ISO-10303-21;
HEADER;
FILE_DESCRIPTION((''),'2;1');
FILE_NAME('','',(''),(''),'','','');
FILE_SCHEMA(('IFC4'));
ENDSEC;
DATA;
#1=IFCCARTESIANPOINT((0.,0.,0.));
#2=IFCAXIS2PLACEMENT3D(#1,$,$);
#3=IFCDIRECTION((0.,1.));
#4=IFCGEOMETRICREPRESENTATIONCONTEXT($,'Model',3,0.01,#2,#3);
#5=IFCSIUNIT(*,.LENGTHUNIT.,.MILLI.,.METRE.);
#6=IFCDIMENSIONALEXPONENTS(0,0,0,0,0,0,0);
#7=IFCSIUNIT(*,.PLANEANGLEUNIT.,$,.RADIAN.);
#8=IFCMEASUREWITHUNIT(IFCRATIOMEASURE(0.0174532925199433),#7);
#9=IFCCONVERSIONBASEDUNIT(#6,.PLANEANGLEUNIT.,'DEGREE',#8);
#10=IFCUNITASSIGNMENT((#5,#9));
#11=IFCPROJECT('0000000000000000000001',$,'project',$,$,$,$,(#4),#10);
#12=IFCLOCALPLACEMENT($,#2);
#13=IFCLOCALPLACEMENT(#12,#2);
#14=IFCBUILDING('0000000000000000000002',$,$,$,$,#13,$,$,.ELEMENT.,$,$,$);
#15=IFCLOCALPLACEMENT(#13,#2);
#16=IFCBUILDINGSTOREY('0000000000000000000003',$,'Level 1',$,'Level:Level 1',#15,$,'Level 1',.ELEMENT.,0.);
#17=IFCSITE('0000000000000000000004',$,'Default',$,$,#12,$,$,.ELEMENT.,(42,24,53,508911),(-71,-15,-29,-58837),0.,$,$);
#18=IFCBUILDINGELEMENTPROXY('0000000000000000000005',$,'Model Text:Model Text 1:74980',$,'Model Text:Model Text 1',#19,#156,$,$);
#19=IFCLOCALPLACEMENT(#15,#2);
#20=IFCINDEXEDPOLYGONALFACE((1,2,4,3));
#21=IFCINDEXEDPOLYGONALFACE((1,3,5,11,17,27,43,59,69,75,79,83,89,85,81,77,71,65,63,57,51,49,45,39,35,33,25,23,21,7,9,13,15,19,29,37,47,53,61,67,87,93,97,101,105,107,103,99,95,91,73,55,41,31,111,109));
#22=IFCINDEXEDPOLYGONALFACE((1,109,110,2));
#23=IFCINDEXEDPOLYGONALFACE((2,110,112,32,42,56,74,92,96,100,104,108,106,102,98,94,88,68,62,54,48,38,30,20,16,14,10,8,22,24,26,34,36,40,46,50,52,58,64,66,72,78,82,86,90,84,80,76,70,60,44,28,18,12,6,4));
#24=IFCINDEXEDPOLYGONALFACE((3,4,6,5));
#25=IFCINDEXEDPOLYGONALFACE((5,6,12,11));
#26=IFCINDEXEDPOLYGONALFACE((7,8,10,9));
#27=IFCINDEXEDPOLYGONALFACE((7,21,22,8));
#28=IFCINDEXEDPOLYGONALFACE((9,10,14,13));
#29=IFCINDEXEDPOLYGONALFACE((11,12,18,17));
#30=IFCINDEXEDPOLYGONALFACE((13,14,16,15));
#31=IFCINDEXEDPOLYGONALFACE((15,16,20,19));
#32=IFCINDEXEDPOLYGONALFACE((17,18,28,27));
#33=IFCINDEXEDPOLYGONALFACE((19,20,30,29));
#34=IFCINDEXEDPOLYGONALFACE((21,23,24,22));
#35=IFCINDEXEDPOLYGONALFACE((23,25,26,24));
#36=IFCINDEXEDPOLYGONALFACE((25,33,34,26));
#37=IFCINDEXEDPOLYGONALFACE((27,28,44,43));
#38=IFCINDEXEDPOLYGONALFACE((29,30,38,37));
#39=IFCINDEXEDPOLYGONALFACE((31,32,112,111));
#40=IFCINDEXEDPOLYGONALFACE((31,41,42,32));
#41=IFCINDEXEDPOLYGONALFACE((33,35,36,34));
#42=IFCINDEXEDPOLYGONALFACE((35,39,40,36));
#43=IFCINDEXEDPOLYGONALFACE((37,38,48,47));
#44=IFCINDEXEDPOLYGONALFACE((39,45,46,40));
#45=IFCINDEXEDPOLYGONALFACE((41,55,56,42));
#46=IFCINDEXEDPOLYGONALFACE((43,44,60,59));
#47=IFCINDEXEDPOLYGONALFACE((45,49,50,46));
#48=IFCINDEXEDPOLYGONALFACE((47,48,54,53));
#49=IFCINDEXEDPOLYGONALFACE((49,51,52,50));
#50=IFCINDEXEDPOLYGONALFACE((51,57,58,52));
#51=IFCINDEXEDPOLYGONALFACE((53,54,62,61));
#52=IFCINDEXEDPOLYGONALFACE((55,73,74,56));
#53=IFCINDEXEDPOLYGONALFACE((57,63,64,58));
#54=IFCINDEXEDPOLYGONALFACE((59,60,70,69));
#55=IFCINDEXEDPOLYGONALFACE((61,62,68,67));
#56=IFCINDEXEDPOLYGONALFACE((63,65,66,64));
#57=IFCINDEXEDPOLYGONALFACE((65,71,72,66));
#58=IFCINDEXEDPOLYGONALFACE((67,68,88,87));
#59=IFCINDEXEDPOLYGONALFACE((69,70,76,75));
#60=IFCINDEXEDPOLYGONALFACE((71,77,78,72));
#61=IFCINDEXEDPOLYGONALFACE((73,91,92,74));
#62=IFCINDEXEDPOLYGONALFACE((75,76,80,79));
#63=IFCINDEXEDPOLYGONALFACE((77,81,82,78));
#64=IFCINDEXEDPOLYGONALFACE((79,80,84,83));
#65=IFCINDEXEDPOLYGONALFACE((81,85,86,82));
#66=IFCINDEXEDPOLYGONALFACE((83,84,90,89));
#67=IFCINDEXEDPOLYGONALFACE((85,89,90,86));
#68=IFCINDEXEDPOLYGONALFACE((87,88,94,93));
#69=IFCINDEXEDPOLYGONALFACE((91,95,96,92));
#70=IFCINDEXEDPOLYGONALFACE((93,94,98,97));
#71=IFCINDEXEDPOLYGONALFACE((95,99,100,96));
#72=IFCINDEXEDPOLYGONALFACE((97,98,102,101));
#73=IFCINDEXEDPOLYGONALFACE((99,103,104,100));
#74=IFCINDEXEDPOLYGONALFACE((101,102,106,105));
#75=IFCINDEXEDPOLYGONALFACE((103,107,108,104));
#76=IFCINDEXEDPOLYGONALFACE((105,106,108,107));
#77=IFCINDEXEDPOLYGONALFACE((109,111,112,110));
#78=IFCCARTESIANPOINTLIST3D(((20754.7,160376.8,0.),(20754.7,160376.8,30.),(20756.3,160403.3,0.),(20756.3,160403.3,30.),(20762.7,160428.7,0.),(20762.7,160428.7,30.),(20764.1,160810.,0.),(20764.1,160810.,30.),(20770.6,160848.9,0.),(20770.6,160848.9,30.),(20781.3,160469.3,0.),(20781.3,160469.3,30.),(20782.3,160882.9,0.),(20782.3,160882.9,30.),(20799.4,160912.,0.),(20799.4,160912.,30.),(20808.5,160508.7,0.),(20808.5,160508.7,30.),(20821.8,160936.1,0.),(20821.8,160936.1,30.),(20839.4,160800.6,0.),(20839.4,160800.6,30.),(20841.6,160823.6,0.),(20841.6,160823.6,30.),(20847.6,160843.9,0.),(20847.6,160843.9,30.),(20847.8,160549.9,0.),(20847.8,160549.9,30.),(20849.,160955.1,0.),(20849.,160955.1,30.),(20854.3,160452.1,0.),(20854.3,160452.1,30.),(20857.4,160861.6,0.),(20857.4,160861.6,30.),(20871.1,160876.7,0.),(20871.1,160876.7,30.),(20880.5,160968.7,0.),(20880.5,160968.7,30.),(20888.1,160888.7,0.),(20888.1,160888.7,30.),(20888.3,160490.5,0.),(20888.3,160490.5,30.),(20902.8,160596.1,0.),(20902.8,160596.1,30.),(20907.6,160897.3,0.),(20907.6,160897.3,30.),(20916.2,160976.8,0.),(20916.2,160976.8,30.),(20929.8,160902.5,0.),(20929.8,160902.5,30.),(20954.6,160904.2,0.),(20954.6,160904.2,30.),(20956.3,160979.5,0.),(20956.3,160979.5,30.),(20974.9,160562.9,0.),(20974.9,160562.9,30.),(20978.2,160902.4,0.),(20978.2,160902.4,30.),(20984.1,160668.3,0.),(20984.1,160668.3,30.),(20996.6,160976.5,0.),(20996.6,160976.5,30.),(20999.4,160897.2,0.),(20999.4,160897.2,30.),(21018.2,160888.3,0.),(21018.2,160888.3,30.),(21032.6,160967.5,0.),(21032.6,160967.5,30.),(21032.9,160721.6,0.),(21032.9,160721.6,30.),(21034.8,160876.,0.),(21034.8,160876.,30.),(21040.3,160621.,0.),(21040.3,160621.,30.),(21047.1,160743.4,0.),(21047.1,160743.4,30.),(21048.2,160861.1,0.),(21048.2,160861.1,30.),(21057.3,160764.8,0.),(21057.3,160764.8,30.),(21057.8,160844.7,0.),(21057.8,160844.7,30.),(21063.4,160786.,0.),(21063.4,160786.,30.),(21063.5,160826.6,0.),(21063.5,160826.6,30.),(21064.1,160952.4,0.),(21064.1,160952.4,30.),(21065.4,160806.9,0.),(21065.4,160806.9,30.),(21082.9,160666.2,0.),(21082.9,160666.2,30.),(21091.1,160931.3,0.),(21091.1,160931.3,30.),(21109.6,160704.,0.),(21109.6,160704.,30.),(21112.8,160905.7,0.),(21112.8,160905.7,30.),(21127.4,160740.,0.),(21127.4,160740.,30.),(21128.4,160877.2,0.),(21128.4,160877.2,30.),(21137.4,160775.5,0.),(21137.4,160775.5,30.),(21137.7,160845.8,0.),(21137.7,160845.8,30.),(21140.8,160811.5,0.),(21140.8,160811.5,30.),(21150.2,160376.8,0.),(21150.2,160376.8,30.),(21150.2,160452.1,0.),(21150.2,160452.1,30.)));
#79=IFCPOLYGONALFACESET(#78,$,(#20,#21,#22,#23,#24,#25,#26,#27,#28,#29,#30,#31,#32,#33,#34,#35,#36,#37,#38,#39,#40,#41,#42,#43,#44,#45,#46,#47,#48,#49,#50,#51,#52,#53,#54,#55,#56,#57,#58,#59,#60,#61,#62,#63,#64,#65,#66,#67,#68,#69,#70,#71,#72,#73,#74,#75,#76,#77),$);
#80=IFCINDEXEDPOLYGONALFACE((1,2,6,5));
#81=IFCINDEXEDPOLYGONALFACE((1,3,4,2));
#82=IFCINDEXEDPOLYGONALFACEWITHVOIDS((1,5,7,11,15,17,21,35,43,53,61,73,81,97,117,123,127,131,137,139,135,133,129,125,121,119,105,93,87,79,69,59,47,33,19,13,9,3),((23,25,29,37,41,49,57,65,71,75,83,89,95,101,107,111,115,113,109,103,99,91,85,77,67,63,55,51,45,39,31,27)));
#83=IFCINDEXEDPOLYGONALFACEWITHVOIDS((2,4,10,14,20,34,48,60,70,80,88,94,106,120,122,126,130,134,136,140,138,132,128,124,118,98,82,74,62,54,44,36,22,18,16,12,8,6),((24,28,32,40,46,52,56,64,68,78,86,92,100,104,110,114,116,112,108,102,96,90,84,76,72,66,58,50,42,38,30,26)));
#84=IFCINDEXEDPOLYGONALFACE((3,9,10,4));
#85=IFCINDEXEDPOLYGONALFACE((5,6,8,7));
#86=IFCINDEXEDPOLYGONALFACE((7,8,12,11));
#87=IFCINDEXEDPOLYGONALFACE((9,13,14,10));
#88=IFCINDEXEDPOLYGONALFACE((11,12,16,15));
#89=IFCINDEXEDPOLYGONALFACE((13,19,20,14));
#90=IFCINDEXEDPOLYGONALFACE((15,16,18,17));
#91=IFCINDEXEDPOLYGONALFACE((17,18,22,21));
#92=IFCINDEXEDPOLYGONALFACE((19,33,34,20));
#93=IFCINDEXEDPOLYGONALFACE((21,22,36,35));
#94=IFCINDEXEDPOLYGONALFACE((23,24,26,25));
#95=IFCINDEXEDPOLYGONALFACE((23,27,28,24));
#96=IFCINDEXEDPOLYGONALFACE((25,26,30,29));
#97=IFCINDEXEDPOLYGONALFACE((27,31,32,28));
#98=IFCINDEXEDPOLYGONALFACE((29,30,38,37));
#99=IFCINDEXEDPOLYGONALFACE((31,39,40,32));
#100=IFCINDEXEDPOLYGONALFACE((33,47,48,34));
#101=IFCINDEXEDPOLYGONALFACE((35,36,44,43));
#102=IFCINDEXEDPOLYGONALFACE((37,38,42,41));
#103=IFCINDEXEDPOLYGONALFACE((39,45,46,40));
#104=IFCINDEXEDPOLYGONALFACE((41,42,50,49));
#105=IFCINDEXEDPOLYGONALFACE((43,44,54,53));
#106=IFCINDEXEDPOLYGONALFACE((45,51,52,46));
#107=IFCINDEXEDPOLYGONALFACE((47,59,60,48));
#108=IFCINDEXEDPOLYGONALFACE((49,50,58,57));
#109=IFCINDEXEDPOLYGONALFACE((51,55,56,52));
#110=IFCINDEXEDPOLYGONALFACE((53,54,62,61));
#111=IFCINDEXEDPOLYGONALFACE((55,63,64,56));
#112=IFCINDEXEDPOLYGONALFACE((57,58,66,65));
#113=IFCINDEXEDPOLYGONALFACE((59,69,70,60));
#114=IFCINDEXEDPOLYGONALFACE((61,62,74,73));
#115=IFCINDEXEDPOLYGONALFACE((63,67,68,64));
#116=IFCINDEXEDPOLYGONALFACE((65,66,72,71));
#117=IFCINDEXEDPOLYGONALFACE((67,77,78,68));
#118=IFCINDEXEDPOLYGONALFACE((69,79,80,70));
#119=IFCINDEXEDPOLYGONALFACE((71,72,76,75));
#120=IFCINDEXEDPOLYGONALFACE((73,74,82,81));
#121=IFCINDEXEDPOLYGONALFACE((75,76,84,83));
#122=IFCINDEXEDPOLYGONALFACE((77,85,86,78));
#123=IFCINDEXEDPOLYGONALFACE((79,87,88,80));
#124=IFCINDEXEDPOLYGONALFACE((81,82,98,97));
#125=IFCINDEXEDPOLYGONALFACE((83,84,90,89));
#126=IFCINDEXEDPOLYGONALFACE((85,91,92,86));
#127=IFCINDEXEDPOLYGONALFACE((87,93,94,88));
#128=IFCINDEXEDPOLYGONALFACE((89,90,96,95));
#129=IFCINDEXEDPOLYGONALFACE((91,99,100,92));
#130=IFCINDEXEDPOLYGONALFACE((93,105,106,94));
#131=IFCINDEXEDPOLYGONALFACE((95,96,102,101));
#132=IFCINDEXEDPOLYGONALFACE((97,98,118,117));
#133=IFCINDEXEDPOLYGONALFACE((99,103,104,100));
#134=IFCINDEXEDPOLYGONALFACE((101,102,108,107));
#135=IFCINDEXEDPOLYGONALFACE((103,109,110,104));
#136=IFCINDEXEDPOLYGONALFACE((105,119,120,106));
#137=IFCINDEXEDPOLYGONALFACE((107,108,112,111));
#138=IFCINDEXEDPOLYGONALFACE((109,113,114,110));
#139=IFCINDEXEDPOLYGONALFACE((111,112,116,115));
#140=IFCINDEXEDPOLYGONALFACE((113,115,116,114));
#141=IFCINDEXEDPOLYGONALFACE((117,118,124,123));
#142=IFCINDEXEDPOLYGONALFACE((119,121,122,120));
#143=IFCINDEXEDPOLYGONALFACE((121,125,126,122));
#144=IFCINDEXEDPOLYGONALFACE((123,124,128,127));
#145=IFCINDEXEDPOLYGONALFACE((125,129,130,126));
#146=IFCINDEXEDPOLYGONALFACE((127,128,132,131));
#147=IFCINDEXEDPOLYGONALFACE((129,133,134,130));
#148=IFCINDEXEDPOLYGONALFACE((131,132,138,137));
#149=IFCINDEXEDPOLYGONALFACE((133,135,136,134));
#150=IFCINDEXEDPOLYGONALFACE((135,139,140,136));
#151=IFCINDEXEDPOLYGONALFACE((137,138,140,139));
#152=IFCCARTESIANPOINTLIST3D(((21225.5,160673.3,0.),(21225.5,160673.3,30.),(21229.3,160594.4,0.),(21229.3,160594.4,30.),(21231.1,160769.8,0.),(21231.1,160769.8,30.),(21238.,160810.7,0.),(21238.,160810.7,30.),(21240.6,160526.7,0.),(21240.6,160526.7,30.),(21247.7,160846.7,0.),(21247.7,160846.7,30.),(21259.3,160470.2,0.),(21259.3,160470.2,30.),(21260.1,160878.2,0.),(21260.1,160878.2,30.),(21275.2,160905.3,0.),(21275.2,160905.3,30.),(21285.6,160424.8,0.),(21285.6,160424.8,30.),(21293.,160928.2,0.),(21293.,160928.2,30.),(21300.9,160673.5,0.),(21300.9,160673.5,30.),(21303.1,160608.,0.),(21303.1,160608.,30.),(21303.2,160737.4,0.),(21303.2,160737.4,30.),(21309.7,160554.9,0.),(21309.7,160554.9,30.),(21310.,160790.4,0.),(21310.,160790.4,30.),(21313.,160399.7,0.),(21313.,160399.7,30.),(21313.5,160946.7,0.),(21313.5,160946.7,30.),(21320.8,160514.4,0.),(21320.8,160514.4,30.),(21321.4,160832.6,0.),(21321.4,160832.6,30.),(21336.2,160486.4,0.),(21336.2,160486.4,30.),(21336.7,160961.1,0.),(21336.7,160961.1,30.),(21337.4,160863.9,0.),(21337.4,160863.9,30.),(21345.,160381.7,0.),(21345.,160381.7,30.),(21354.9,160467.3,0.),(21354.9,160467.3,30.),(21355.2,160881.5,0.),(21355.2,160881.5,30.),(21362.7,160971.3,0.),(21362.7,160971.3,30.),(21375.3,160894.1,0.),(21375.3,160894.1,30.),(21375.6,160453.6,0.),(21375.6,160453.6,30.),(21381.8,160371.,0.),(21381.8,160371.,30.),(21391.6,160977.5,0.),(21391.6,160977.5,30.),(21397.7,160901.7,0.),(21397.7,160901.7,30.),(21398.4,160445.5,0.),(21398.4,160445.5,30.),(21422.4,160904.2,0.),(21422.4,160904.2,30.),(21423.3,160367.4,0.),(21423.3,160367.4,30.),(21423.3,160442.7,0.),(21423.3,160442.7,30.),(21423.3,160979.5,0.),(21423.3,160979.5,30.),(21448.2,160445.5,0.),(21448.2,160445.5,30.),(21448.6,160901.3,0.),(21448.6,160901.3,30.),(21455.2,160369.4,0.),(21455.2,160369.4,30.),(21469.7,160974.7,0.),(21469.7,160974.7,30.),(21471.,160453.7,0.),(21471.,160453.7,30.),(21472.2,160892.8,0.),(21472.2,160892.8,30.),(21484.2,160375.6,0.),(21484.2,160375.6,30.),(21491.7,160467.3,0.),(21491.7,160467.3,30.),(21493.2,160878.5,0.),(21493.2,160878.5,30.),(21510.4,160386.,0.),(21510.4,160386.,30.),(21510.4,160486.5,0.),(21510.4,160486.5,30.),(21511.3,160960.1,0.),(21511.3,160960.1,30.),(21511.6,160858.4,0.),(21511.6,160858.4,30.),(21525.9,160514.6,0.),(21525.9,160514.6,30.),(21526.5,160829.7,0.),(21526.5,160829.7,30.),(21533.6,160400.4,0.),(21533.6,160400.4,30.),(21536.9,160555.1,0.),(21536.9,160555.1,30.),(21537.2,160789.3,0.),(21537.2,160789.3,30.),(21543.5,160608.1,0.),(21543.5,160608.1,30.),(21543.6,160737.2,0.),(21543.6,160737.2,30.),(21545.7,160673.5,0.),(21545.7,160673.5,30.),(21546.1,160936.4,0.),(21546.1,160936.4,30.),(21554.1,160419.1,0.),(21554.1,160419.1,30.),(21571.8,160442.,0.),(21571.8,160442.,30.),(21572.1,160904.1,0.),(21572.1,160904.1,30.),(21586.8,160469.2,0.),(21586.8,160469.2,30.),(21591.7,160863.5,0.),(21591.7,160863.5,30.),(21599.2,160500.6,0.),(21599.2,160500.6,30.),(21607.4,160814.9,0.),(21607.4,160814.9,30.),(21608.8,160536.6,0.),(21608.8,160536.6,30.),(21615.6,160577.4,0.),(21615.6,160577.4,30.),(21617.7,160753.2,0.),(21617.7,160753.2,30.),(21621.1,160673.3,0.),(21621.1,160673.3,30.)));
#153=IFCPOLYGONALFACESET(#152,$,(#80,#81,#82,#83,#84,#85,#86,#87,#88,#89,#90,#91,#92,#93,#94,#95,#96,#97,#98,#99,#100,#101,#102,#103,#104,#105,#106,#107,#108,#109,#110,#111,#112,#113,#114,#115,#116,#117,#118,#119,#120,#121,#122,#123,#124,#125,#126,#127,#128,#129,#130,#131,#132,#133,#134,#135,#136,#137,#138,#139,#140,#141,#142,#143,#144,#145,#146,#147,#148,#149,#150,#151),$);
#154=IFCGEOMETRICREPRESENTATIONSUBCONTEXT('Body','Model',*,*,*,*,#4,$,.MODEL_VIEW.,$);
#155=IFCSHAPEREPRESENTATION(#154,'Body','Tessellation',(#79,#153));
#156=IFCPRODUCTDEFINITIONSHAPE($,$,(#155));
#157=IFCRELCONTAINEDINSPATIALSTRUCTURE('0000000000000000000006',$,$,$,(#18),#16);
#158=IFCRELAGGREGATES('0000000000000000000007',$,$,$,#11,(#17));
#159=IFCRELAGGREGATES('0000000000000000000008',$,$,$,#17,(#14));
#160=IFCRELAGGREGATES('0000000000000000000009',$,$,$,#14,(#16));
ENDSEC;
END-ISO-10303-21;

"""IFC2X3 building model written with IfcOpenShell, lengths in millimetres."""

from ifc_helpers import new_model, entity, si_unit, converted_unit, direction, frame, origin, place, context, subcontext, project, spatial, polyline, outline, extrude, element, save


model = new_model("IFC2X3")

# Units and contexts
model_context = context("Model", 3, precision=0.01, world=origin(), true_north=direction((0.0, 1.0)))
body_context = subcontext(model_context, "Body", "Model", "MODEL_VIEW")
ifc_project = project(units=[si_unit("LENGTHUNIT", "METRE", prefix="MILLI"), converted_unit("PLANEANGLEUNIT", "DEGREE", entity("IfcRatioMeasure", 0.0174532925199433), si_unit("PLANEANGLEUNIT", "RADIAN"), dimensions=[0, 0, 0, 0, 0, 0, 0])], contexts=[model_context])

# Site, building, storey
site_placement = place(None, origin())
site = spatial("IfcSite", under=ifc_project, at=site_placement, Name="Default", CompositionType="ELEMENT", RefLatitude=(42, 24, 53, 508911), RefLongitude=(-71, -15, -29, -58837), RefElevation=0.0)
building_placement = place(site_placement, origin())
building = spatial("IfcBuilding", under=site, at=building_placement, CompositionType="ELEMENT")
storey_placement = place(building_placement, origin())
storey = spatial("IfcBuildingStorey", under=building, at=storey_placement, Name="Level 1", ObjectType="Level:Level 1", LongName="Level 1", CompositionType="ELEMENT", Elevation=0.0)

# Building element proxy
proxy_1_placement = place(storey_placement, origin())
element("IfcBuildingElementProxy", 1, at=proxy_1_placement, inside=storey, Name="Model Text:Model Text 1:74980", ObjectType="Model Text:Model Text 1", context=body_context, shape_type="SweptSolid", body=[
    extrude(outline(polyline([(-190.2, -317.5), (-190.2, -392.8), (205.4, -392.8), (203.7, -366.3), (197.3, -340.9), (178.7, -300.3), (151.5, -260.9), (112.2, -219.7), (57.2, -173.6), (-24.1, -101.3), (-72.9, -48.0), (-87.1, -26.3), (-97.3, -4.8), (-103.4, 16.4), (-105.4, 37.3), (-103.5, 57.0), (-97.7, 75.0), (-88.2, 91.5), (-74.7, 106.4), (-58.2, 118.7), (-39.4, 127.5), (-18.2, 132.8), (5.4, 134.6), (30.2, 132.9), (52.4, 127.7), (72.0, 119.1), (88.9, 107.1), (102.6, 92.0), (112.5, 74.3), (118.5, 54.0), (120.6, 31.0), (196.0, 40.4), (189.5, 79.3), (177.7, 113.3), (160.6, 142.4), (138.2, 166.5), (111.0, 185.5), (79.5, 199.1), (43.8, 207.2), (3.8, 209.9), (-36.6, 206.9), (-72.5, 197.9), (-104.0, 182.8), (-131.1, 161.7), (-152.8, 136.1), (-168.3, 107.6), (-177.6, 76.2), (-180.8, 41.9), (-177.4, 5.8), (-167.4, -29.6), (-149.5, -65.6), (-122.8, -103.4), (-80.3, -148.6), (-14.9, -206.7), (71.8, -279.1), (105.8, -317.5), (-190.2, -317.5)])), frame((20960.0, 160769.6, 0.0), z_axis=(0.0, 0.0, -1.0), x_axis=(-1.0, 0.0, 0.0)), (0.0, 0.0, -1.0), 30.0),
    extrude(outline(polyline([(-10.6, -198.7), (68.3, -198.7), (136.5, -190.7), (193.9, -174.7), (240.5, -150.6), (266.9, -124.4), (286.3, -93.2), (298.8, -57.0), (304.3, -15.7), (303.8, 16.2), (299.0, 45.5), (289.9, 72.1), (276.6, 96.0), (258.9, 117.3), (236.9, 136.2), (210.4, 152.5), (179.6, 166.3), (144.1, 177.6), (103.7, 186.3), (8.2, 196.4), (-71.8, 196.7), (-134.0, 189.4), (-183.3, 176.1), (-224.7, 158.4), (-258.2, 133.9), (-283.5, 100.3), (-300.1, 59.5), (-307.1, 13.4), (-306.6, -18.4), (-301.8, -47.5), (-292.8, -74.0), (-279.6, -97.9), (-262.0, -119.2), (-240.0, -138.1), (-213.6, -154.5), (-182.8, -168.4), (-147.3, -179.8), (-106.7, -188.6), (-10.6, -198.7)]), holes=[polyline([(-7.2, -123.5), (-71.0, -118.2), (-123.6, -108.8), (-165.2, -95.4), (-195.7, -78.0), (-212.4, -59.4), (-224.1, -38.7), (-230.6, -15.9), (-231.9, 8.9), (-227.8, 35.0), (-218.1, 58.1), (-202.8, 78.4), (-182.0, 95.8), (-152.6, 109.4), (-111.7, 118.1), (-59.4, 122.0), (4.4, 121.1), (69.6, 115.8), (122.2, 106.7), (162.2, 93.7), (189.5, 77.0), (207.7, 57.4), (220.4, 36.0), (227.5, 12.8), (229.1, -12.1), (225.2, -36.8), (215.9, -59.2), (201.3, -79.3), (181.4, -97.1), (152.6, -111.2), (111.6, -120.3), (58.3, -124.4), (-7.2, -123.5)])]), frame((21424.6, 160672.1, 0.0), z_axis=(0.0, 0.0, 1.0), x_axis=(0.047515, -0.998871, 0.0)), (0.0, 0.0, 1.0), 30.0),
])

save(model, "model.ifc")
